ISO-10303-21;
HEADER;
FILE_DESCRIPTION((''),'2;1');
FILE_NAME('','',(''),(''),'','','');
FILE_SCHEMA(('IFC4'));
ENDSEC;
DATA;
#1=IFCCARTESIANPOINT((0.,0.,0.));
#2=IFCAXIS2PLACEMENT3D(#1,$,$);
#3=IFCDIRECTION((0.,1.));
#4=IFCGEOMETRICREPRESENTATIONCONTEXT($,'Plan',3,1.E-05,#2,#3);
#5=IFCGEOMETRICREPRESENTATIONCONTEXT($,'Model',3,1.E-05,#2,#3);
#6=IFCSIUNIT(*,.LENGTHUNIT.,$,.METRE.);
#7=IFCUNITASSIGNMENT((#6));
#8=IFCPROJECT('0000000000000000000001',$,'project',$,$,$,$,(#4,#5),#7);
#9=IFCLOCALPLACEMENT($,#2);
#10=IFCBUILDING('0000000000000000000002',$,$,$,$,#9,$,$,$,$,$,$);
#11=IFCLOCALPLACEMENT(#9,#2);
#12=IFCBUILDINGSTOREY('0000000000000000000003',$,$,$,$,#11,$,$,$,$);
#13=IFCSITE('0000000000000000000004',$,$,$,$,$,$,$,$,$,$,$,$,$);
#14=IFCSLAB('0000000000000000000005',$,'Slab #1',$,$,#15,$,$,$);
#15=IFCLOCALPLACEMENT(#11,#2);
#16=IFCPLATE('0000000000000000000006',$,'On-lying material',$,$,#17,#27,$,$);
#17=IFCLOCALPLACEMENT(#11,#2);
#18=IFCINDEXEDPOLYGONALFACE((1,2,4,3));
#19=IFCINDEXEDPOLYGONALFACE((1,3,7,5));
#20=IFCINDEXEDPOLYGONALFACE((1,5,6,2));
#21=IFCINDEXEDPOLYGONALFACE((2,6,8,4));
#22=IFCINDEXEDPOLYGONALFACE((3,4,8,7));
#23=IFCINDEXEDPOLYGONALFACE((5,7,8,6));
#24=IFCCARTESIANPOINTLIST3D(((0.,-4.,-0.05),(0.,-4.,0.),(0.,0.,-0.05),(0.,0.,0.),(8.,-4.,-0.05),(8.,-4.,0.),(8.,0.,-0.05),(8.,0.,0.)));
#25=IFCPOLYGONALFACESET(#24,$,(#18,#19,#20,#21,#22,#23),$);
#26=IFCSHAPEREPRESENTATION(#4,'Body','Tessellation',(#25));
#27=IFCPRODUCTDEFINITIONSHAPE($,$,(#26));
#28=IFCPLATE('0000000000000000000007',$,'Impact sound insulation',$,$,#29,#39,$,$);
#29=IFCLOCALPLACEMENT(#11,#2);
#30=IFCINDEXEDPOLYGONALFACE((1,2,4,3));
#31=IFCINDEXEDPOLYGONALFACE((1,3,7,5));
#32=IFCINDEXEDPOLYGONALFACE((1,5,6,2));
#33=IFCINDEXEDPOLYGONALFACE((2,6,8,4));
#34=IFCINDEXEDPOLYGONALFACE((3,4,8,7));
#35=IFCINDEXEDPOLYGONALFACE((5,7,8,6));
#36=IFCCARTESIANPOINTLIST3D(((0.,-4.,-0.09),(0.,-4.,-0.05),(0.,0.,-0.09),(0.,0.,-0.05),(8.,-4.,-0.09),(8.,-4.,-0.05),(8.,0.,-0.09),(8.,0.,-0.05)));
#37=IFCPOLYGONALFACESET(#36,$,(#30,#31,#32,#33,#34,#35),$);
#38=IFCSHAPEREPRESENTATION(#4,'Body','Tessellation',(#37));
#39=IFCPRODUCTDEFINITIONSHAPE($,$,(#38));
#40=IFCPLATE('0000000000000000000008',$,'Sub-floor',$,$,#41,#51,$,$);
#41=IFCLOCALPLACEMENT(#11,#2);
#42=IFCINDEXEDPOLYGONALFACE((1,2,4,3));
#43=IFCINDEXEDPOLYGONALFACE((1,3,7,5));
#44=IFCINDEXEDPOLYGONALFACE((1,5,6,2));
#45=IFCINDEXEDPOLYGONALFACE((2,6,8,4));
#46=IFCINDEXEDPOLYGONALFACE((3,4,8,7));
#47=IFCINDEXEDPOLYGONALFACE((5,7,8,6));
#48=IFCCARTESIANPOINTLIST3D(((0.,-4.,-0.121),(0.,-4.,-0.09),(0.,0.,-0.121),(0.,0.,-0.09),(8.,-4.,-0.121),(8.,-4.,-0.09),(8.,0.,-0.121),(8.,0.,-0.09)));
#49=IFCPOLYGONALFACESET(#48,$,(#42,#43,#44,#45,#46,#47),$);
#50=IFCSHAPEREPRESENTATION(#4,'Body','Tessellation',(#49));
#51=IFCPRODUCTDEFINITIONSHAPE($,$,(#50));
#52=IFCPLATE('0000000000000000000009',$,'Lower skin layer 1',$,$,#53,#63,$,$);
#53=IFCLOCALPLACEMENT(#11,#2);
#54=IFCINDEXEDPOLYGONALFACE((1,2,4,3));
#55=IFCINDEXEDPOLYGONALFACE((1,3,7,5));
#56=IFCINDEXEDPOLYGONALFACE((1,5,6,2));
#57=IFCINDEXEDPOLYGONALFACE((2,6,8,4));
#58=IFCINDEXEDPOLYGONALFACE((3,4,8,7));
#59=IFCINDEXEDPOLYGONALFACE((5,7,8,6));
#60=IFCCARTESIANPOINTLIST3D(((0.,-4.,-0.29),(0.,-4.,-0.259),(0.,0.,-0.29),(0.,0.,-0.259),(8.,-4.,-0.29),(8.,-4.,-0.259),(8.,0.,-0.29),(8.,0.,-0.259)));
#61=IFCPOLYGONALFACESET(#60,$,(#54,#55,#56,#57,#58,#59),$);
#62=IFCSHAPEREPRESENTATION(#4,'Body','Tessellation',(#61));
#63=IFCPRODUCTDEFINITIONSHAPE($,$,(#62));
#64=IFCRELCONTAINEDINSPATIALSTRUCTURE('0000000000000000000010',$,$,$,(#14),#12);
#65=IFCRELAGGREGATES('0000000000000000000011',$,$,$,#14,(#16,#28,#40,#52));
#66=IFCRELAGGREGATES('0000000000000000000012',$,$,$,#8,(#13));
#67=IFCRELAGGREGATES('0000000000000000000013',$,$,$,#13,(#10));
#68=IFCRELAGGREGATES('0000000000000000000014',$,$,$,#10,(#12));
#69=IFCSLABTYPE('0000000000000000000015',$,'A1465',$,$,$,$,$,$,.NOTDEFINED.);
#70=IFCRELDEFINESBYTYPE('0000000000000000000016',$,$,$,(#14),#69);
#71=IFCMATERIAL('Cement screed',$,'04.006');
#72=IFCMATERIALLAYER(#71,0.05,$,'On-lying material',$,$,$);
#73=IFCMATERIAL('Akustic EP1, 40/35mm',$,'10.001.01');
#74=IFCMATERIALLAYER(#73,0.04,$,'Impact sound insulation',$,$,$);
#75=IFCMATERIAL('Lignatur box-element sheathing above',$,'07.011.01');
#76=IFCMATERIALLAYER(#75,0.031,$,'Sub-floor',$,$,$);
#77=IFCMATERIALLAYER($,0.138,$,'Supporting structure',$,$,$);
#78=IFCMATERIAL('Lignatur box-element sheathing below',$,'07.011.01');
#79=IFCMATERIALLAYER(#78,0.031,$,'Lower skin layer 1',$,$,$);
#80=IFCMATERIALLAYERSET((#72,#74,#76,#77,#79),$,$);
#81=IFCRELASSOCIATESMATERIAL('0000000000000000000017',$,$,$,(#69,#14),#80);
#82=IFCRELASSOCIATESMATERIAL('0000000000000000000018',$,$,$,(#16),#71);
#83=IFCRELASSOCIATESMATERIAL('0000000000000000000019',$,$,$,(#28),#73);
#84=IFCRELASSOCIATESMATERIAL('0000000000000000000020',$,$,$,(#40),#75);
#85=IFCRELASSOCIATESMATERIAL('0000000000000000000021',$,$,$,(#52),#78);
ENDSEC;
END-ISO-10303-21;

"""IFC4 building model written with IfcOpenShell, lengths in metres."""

from ifc_helpers import new_model, si_unit, direction, frame, frame_2d, origin, origin_with_axes, place, context, project, spatial, rectangle, extrude, material, layer, layer_set, type_object, element, aggregate, save


model = new_model("IFC4")

# Units and contexts
plan_context = context("Plan", 3, precision=1e-05, world=origin(), true_north=direction((0.0, 1.0)))
model_context = context("Model", 3, precision=1e-05, world=origin(), true_north=direction((0.0, 1.0)))
ifc_project = project(units=[si_unit("LENGTHUNIT", "METRE")], contexts=[plan_context, model_context])

# Site, building, storey
site = spatial("IfcSite", under=ifc_project)
building_placement = place(None, origin())
building = spatial("IfcBuilding", under=site, at=building_placement)
storey_placement = place(building_placement, origin())
storey = spatial("IfcBuildingStorey", under=building, at=storey_placement)

# Slab, plates
ifc_material_1 = material(Name="Cement screed", Category="04.006")
ifc_layer_1 = layer(ifc_material_1, 0.05, Name="On-lying material")
ifc_material_2 = material(Name="Akustic EP1, 40/35mm", Category="10.001.01")
ifc_layer_2 = layer(ifc_material_2, 0.04, Name="Impact sound insulation")
ifc_material_3 = material(Name="Lignatur box-element sheathing above", Category="07.011.01")
ifc_layer_3 = layer(ifc_material_3, 0.031, Name="Sub-floor")
ifc_layer_4 = layer(None, 0.138, Name="Supporting structure")
ifc_material_4 = material(Name="Lignatur box-element sheathing below", Category="07.011.01")
ifc_layer_5 = layer(ifc_material_4, 0.031, Name="Lower skin layer 1")
ifc_layer_set = layer_set([ifc_layer_1, ifc_layer_2, ifc_layer_3, ifc_layer_4, ifc_layer_5])
slab_type = type_object("IfcSlabType", Name="A1465", PredefinedType="NOTDEFINED", material=ifc_layer_set)
slab_placement = place(None, frame((0.0, 0.0, 0.0), z_axis=(0.0, 0.0, -1.0), x_axis=(1.0, 0.0, 0.0)))
slab = element("IfcSlab", 1, at=slab_placement, inside=storey, type_object=slab_type, material=ifc_layer_set, Name="Slab #1")
plate_1_placement = place(slab_placement, origin())
plate_1 = element("IfcPlate", 2, at=plate_1_placement, material=ifc_material_1, Name="On-lying material", context=plan_context, shape_type="SweptSolid", body=[
    extrude(rectangle(XDim=8.0, YDim=4.0, at=frame_2d((4.0, 2.0), x_axis=(1.0, 0.0))), origin_with_axes(), (0.0, 0.0, 1.0), 0.05),
])
plate_2_placement = place(slab_placement, origin())
plate_2 = element("IfcPlate", 3, at=plate_2_placement, material=ifc_material_2, Name="Impact sound insulation", context=plan_context, shape_type="SweptSolid", body=[
    extrude(rectangle(XDim=8.0, YDim=4.0, at=frame_2d((4.0, 2.0), x_axis=(1.0, 0.0))), frame((0.0, 0.0, 0.05), z_axis=(0.0, 0.0, 1.0), x_axis=(1.0, 0.0, 0.0)), (0.0, 0.0, 1.0), 0.04),
])
plate_3_placement = place(slab_placement, origin())
plate_3 = element("IfcPlate", 4, at=plate_3_placement, material=ifc_material_3, Name="Sub-floor", context=plan_context, shape_type="SweptSolid", body=[
    extrude(rectangle(XDim=8.0, YDim=4.0, at=frame_2d((4.0, 2.0), x_axis=(1.0, 0.0))), frame((0.0, 0.0, 0.09), z_axis=(0.0, 0.0, 1.0), x_axis=(1.0, 0.0, 0.0)), (0.0, 0.0, 1.0), 0.031),
])
plate_4_placement = place(slab_placement, origin())
plate_4 = element("IfcPlate", 5, at=plate_4_placement, material=ifc_material_4, Name="Lower skin layer 1", context=plan_context, shape_type="SweptSolid", body=[
    extrude(rectangle(XDim=8.0, YDim=4.0, at=frame_2d((4.0, 2.0), x_axis=(1.0, 0.0))), frame((0.0, 0.0, 0.259), z_axis=(0.0, 0.0, 1.0), x_axis=(1.0, 0.0, 0.0)), (0.0, 0.0, 1.0), 0.031),
])
aggregate(slab, [plate_1, plate_2, plate_3, plate_4])

save(model, "model.ifc")
